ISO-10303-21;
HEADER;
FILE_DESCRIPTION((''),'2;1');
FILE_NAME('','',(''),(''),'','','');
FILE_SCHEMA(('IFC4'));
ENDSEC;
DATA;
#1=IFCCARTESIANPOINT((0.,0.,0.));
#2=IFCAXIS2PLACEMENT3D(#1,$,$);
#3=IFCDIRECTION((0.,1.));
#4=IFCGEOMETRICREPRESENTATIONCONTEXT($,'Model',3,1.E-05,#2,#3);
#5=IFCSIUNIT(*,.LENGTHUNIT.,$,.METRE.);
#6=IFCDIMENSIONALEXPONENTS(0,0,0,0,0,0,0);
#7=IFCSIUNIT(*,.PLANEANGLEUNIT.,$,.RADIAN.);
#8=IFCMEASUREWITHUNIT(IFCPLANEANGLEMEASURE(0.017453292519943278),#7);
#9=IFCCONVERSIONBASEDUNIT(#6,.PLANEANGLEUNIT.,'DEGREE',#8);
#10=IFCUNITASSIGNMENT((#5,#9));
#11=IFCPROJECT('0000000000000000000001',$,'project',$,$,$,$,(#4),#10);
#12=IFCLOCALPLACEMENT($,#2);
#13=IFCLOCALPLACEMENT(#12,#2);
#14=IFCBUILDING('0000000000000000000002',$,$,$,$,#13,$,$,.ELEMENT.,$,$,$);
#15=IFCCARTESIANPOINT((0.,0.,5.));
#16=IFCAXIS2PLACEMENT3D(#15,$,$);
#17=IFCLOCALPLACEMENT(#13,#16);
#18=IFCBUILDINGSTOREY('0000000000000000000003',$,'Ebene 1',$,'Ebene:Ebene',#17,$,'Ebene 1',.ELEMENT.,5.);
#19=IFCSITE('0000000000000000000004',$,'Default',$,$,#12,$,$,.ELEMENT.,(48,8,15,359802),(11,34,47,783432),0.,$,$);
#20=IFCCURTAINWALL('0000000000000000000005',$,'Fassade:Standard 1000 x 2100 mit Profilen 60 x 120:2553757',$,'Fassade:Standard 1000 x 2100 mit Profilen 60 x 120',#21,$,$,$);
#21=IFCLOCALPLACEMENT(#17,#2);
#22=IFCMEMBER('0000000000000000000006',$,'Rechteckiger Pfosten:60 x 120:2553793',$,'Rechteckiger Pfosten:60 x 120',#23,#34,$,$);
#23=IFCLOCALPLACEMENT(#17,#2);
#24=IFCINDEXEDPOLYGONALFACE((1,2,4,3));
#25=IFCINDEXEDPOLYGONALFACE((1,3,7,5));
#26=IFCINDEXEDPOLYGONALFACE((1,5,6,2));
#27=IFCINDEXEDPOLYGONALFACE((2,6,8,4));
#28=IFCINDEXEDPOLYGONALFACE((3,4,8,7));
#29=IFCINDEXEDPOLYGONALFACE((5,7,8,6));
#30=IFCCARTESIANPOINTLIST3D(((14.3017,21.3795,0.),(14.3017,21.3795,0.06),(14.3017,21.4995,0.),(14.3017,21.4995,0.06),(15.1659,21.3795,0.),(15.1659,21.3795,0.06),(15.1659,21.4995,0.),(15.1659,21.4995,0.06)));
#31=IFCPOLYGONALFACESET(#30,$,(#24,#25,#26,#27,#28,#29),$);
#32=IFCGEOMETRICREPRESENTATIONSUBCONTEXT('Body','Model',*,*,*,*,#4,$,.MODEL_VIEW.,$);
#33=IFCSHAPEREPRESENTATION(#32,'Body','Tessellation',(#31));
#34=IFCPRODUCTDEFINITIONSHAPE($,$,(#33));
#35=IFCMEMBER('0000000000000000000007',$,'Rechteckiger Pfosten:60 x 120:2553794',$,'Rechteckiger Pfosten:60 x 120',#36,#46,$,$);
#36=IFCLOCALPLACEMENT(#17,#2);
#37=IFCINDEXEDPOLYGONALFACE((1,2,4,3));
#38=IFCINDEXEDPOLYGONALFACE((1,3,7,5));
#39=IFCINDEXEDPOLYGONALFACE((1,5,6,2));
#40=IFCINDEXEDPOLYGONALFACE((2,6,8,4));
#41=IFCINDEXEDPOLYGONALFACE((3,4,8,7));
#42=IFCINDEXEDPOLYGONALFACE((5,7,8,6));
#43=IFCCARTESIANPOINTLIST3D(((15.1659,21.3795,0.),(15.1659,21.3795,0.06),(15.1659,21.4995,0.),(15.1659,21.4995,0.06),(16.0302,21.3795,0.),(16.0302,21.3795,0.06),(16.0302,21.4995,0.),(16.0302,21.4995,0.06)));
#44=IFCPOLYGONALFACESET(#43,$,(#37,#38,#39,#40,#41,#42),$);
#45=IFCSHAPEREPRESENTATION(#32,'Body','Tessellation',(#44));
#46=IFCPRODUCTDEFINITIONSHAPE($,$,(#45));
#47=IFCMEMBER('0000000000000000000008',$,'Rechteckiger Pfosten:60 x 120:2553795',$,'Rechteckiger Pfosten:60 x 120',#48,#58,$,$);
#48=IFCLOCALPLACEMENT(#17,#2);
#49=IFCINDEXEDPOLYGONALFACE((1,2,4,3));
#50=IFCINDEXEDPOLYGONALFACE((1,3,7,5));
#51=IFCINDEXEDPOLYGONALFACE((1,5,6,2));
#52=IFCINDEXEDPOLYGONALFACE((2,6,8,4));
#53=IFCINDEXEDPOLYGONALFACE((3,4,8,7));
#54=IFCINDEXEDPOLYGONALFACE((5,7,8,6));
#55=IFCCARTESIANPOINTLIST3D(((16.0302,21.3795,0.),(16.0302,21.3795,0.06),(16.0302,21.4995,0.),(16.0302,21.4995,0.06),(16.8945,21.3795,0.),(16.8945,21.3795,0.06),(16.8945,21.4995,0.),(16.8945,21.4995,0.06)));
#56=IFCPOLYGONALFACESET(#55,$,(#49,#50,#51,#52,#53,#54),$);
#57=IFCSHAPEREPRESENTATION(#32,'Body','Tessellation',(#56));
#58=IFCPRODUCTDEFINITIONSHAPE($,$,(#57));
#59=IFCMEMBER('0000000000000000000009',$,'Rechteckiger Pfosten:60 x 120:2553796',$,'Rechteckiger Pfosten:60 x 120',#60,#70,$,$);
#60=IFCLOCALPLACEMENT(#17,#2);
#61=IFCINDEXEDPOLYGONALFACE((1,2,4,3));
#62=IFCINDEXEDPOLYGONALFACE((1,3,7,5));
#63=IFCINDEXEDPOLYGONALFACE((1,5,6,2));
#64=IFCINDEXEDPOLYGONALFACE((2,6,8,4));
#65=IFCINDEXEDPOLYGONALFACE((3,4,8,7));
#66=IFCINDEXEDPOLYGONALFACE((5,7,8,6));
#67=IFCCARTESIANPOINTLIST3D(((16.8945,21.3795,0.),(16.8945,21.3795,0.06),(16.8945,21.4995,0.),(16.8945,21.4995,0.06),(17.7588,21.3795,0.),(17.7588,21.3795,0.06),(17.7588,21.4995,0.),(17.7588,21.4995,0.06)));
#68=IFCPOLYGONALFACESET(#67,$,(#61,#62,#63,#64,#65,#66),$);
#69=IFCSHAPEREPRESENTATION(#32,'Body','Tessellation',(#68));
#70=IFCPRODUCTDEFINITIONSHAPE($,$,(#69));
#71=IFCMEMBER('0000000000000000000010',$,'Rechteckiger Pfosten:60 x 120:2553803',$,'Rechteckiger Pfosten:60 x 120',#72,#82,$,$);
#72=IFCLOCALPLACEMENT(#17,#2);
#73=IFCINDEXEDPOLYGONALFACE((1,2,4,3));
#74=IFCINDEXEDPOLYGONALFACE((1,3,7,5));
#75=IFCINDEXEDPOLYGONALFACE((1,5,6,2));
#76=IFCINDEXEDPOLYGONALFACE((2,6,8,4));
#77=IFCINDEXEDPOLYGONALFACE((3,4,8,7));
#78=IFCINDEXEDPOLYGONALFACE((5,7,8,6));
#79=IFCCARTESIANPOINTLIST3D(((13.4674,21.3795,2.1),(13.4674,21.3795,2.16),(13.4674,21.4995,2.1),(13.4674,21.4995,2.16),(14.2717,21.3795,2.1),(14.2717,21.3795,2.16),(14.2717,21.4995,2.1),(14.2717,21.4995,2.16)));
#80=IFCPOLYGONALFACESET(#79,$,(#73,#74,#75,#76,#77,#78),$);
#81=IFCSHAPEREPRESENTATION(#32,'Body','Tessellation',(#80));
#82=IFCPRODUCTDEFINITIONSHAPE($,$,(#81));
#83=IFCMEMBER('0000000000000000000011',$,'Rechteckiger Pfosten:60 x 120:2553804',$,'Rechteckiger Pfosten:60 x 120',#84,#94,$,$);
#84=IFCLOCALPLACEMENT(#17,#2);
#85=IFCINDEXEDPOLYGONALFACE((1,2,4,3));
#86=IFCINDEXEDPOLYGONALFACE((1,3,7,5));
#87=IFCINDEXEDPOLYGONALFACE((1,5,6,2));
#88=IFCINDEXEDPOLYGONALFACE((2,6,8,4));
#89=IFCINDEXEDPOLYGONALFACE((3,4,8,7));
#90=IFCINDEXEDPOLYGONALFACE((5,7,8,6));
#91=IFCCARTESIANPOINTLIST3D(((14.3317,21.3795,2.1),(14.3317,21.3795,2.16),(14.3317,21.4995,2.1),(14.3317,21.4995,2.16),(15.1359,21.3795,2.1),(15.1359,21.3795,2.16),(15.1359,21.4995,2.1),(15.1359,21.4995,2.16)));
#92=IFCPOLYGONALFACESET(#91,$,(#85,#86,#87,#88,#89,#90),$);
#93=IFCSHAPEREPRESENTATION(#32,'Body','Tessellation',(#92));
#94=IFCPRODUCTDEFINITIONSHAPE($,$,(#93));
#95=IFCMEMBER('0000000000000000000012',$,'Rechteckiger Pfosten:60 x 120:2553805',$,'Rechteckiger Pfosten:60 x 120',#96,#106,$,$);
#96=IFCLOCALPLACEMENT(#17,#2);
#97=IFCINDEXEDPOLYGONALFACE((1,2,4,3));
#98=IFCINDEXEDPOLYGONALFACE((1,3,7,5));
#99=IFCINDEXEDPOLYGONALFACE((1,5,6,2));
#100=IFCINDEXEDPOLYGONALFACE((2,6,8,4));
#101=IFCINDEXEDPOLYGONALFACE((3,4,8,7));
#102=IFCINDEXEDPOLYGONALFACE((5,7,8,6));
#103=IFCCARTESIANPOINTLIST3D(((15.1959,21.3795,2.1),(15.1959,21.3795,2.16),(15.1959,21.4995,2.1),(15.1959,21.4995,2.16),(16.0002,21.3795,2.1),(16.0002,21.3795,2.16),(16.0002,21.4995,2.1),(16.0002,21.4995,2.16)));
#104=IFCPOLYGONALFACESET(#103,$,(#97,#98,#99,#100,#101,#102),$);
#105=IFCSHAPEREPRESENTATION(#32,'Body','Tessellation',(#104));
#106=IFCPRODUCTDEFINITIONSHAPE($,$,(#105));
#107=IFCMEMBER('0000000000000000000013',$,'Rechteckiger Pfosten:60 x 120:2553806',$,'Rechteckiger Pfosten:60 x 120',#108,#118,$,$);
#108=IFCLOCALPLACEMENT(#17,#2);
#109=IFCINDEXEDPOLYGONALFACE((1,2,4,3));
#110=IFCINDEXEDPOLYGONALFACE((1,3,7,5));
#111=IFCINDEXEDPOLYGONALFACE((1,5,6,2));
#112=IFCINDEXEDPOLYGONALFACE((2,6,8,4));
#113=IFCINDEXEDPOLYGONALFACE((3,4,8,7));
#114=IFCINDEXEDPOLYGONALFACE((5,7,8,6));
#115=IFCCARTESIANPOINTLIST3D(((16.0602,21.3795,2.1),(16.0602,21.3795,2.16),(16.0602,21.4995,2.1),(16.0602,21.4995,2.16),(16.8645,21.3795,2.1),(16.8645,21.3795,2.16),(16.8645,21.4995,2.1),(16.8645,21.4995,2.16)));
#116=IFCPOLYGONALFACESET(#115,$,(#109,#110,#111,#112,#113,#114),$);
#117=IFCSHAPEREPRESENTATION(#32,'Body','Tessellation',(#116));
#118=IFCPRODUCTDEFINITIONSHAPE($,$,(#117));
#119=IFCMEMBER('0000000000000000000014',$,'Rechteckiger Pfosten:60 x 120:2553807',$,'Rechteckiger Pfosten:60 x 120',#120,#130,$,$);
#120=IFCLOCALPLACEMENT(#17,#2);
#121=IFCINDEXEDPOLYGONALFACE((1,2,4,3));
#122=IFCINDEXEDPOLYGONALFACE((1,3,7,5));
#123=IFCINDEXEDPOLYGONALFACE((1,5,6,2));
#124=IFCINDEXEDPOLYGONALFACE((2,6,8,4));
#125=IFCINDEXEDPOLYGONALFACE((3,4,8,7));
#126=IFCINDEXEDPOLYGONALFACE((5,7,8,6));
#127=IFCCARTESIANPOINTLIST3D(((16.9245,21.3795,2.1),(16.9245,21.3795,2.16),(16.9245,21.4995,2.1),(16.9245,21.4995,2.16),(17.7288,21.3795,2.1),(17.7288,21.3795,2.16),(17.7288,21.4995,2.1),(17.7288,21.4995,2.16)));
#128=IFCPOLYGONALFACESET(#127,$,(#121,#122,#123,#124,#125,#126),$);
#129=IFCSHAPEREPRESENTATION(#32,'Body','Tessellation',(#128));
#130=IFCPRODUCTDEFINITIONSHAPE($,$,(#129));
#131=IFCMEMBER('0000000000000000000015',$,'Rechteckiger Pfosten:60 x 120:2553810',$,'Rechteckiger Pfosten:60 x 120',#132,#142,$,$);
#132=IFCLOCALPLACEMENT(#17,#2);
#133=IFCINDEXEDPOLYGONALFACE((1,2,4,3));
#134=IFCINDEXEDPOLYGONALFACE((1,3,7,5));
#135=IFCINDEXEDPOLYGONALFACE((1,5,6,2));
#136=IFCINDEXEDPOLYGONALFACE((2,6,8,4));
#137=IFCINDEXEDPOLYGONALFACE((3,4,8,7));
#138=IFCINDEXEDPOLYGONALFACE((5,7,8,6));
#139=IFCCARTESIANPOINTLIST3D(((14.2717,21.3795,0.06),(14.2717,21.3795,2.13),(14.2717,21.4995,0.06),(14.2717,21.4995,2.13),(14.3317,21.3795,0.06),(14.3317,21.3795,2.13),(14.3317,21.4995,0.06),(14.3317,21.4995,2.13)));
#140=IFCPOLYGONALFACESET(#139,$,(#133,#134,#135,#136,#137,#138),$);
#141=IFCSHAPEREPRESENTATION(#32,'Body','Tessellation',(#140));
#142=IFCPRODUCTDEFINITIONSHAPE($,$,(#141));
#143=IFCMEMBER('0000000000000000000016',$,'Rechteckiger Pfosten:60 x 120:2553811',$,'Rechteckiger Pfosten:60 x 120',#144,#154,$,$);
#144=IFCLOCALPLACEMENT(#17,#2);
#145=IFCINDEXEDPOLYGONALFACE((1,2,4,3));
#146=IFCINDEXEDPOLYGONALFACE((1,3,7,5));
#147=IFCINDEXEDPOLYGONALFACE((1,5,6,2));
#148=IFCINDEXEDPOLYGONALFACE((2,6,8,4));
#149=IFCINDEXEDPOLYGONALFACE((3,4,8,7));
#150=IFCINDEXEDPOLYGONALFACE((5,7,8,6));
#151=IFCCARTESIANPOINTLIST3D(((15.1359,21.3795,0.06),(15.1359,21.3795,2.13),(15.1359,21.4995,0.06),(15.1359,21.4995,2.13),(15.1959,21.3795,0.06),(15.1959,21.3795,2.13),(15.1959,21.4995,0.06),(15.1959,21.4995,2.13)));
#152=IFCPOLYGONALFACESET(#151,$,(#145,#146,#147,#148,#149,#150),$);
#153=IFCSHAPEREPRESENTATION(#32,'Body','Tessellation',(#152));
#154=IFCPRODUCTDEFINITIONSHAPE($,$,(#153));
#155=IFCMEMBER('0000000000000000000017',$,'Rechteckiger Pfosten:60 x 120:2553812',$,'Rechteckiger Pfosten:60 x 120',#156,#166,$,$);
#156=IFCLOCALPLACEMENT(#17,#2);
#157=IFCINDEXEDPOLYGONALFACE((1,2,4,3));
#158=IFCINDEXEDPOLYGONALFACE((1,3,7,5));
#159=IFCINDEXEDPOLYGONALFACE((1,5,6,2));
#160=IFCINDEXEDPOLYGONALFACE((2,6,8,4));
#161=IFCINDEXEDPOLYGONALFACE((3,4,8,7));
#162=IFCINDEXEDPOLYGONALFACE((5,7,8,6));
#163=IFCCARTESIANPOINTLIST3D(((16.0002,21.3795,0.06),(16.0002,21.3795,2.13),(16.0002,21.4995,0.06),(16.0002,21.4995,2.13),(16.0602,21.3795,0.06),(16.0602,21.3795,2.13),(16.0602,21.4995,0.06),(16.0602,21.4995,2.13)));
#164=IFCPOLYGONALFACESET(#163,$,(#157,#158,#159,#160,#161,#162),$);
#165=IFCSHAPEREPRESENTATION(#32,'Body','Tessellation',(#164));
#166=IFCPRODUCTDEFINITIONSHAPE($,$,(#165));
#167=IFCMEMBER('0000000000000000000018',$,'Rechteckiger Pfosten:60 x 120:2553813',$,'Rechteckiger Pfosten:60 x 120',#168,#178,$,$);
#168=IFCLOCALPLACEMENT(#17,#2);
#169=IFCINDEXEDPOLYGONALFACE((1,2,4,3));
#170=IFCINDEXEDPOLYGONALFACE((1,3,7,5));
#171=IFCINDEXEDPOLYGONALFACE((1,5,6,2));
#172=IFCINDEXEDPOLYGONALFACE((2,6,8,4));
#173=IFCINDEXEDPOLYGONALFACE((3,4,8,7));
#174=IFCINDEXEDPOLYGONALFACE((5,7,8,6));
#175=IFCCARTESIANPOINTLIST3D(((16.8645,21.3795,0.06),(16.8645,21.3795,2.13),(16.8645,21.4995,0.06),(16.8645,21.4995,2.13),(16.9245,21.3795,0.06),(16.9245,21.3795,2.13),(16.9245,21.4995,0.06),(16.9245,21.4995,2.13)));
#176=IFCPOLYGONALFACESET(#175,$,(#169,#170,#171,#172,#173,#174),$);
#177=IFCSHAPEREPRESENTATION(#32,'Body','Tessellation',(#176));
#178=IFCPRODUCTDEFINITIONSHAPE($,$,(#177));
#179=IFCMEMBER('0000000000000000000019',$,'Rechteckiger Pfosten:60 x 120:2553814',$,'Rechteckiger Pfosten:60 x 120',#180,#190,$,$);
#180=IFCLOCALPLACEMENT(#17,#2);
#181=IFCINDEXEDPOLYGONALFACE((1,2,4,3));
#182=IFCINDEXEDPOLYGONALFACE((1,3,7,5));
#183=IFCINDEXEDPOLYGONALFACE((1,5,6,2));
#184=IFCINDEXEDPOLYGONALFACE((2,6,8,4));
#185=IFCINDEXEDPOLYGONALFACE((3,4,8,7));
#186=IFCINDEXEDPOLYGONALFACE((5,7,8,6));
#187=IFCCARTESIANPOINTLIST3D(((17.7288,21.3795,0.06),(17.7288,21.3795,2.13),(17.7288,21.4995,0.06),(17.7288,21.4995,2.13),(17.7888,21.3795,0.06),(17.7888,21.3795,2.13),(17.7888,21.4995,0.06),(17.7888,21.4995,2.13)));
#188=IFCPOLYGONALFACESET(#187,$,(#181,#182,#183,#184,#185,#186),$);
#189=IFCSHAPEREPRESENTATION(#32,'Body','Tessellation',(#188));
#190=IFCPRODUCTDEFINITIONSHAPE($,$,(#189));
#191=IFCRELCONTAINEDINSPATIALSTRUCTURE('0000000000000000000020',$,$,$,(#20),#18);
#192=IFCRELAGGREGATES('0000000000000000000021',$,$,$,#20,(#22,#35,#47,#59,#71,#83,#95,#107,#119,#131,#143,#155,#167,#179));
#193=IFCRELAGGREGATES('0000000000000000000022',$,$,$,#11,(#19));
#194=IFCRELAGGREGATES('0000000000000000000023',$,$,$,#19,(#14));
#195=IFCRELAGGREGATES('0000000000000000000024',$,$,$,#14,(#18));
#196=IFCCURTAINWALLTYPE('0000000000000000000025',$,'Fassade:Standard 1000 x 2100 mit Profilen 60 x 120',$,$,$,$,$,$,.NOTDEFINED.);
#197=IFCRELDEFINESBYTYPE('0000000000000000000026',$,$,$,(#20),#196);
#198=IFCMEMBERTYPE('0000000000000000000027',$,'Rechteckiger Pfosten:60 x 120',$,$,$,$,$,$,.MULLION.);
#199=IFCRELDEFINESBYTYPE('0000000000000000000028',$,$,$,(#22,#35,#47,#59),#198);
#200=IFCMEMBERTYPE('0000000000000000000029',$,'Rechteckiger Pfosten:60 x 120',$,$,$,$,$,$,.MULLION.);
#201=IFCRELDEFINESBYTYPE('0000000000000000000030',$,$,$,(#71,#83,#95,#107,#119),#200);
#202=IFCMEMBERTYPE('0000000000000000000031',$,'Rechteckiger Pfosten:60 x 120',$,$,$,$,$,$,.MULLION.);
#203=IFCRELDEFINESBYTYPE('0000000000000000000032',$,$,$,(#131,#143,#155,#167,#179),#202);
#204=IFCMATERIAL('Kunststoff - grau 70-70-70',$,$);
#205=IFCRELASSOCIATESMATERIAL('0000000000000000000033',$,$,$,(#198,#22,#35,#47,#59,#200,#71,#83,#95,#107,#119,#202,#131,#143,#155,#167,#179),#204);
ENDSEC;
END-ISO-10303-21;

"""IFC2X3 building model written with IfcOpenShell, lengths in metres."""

from ifc_helpers import new_model, entity, si_unit, converted_unit, direction, frame, frame_2d, origin, origin_2d_with_axis, place, context, subcontext, project, spatial, rectangle, extrude, source, transform, mapped, material, type_object, type_shapes, element, aggregate, save


model = new_model("IFC2X3")

# Units and contexts
model_context = context("Model", 3, precision=1e-05, world=origin(), true_north=direction((0.0, 1.0)))
body_context = subcontext(model_context, "Body", "Model", "MODEL_VIEW")
ifc_project = project(units=[si_unit("LENGTHUNIT", "METRE"), converted_unit("PLANEANGLEUNIT", "DEGREE", entity("IfcPlaneAngleMeasure", 0.017453292519943278), si_unit("PLANEANGLEUNIT", "RADIAN"), dimensions=[0, 0, 0, 0, 0, 0, 0])], contexts=[model_context])

# Site, building, storey
site_placement = place(None, origin())
site = spatial("IfcSite", under=ifc_project, at=site_placement, Name="Default", CompositionType="ELEMENT", RefLatitude=(48, 8, 15, 359802), RefLongitude=(11, 34, 47, 783432), RefElevation=0.0)
building_placement = place(site_placement, origin())
building = spatial("IfcBuilding", under=site, at=building_placement, CompositionType="ELEMENT")
storey_placement = place(building_placement, frame((0.0, 0.0, 5.0)))
storey = spatial("IfcBuildingStorey", under=building, at=storey_placement, Name="Ebene 1", ObjectType="Ebene:Ebene", LongName="Ebene 1", CompositionType="ELEMENT", Elevation=5.0)

# Curtain wall, members
curtain_wall_type = type_object("IfcCurtainWallType", Name="Fassade:Standard 1000 x 2100 mit Profilen 60 x 120", PredefinedType="NOTDEFINED")
curtain_wall_placement = place(storey_placement, frame((0.0, 0.0, -5.0)))
curtain_wall = element("IfcCurtainWall", 1, at=curtain_wall_placement, inside=storey, type_object=curtain_wall_type, Name="Fassade:Standard 1000 x 2100 mit Profilen 60 x 120:2553757", ObjectType="Fassade:Standard 1000 x 2100 mit Profilen 60 x 120")
ifc_material_1 = material(Name="Kunststoff - grau 70-70-70")
member_type_1 = type_object("IfcMemberType", Name="Rechteckiger Pfosten:60 x 120", PredefinedType="MULLION", material=ifc_material_1)
shared_shape_1 = source(origin(), body_context, "Body", "SweptSolid", [
    extrude(rectangle(XDim=0.06, YDim=0.12, at=origin_2d_with_axis()), frame((-0.03, 0.0, -0.8643), z_axis=(0.0, 0.0, 1.0), x_axis=(-1.0, 0.0, 0.0)), (0.0, 0.0, 1.0), 0.8643),
])
type_shapes(member_type_1, [shared_shape_1])
member_1_placement = place(curtain_wall_placement, frame((14.3017, 21.4395, 5.0), z_axis=(-1.0, 0.0, 0.0), x_axis=(0.0, 0.0, -1.0)))
member_1 = element("IfcMember", 2, at=member_1_placement, type_object=member_type_1, material=ifc_material_1, Name="Rechteckiger Pfosten:60 x 120:2553793", ObjectType="Rechteckiger Pfosten:60 x 120", context=body_context, shape_type="MappedRepresentation", body=[
    mapped(shared_shape_1, transform((0.0, 0.0, 0.0), scale=1.0)),
])
member_2_placement = place(curtain_wall_placement, frame((15.1659, 21.4395, 5.0), z_axis=(-1.0, 0.0, 0.0), x_axis=(0.0, 0.0, -1.0)))
member_2 = element("IfcMember", 3, at=member_2_placement, type_object=member_type_1, material=ifc_material_1, Name="Rechteckiger Pfosten:60 x 120:2553794", ObjectType="Rechteckiger Pfosten:60 x 120", context=body_context, shape_type="MappedRepresentation", body=[
    mapped(shared_shape_1, transform((0.0, 0.0, 0.0), scale=1.0)),
])
member_3_placement = place(curtain_wall_placement, frame((16.0302, 21.4395, 5.0), z_axis=(-1.0, 0.0, 0.0), x_axis=(0.0, 0.0, -1.0)))
member_3 = element("IfcMember", 4, at=member_3_placement, type_object=member_type_1, material=ifc_material_1, Name="Rechteckiger Pfosten:60 x 120:2553795", ObjectType="Rechteckiger Pfosten:60 x 120", context=body_context, shape_type="MappedRepresentation", body=[
    mapped(shared_shape_1, transform((0.0, 0.0, 0.0), scale=1.0)),
])
member_4_placement = place(curtain_wall_placement, frame((16.8945, 21.4395, 5.0), z_axis=(-1.0, 0.0, 0.0), x_axis=(0.0, 0.0, -1.0)))
member_4 = element("IfcMember", 5, at=member_4_placement, type_object=member_type_1, material=ifc_material_1, Name="Rechteckiger Pfosten:60 x 120:2553796", ObjectType="Rechteckiger Pfosten:60 x 120", context=body_context, shape_type="MappedRepresentation", body=[
    mapped(shared_shape_1, transform((0.0, 0.0, 0.0), scale=1.0)),
])
member_type_2 = type_object("IfcMemberType", Name="Rechteckiger Pfosten:60 x 120", PredefinedType="MULLION", material=ifc_material_1)
shared_shape_2 = source(origin(), body_context, "Body", "SweptSolid", [
    extrude(rectangle(XDim=0.06, YDim=0.12, at=frame_2d((0.0, 0.0), x_axis=(1.0, 0.0))), frame((0.0, 0.0, -0.8043), z_axis=(0.0, 0.0, 1.0), x_axis=(-1.0, 0.0, 0.0)), (0.0, 0.0, 1.0), 0.8043),
])
type_shapes(member_type_2, [shared_shape_2])
member_5_placement = place(curtain_wall_placement, frame((14.2717, 21.4395, 7.13), z_axis=(1.0, 0.0, 0.0), x_axis=(0.0, 0.0, 1.0)))
member_5 = element("IfcMember", 6, at=member_5_placement, type_object=member_type_2, material=ifc_material_1, Name="Rechteckiger Pfosten:60 x 120:2553803", ObjectType="Rechteckiger Pfosten:60 x 120", context=body_context, shape_type="MappedRepresentation", body=[
    mapped(shared_shape_2, transform((0.0, 0.0, 0.0), scale=1.0)),
])
member_6_placement = place(curtain_wall_placement, frame((15.1359, 21.4395, 7.13), z_axis=(1.0, 0.0, 0.0), x_axis=(0.0, 0.0, 1.0)))
member_6 = element("IfcMember", 7, at=member_6_placement, type_object=member_type_2, material=ifc_material_1, Name="Rechteckiger Pfosten:60 x 120:2553804", ObjectType="Rechteckiger Pfosten:60 x 120", context=body_context, shape_type="MappedRepresentation", body=[
    mapped(shared_shape_2, transform((0.0, 0.0, 0.0), scale=1.0)),
])
member_7_placement = place(curtain_wall_placement, frame((16.0002, 21.4395, 7.13), z_axis=(1.0, 0.0, 0.0), x_axis=(0.0, 0.0, 1.0)))
member_7 = element("IfcMember", 8, at=member_7_placement, type_object=member_type_2, material=ifc_material_1, Name="Rechteckiger Pfosten:60 x 120:2553805", ObjectType="Rechteckiger Pfosten:60 x 120", context=body_context, shape_type="MappedRepresentation", body=[
    mapped(shared_shape_2, transform((0.0, 0.0, 0.0), scale=1.0)),
])
member_8_placement = place(curtain_wall_placement, frame((16.8645, 21.4395, 7.13), z_axis=(1.0, 0.0, 0.0), x_axis=(0.0, 0.0, 1.0)))
member_8 = element("IfcMember", 9, at=member_8_placement, type_object=member_type_2, material=ifc_material_1, Name="Rechteckiger Pfosten:60 x 120:2553806", ObjectType="Rechteckiger Pfosten:60 x 120", context=body_context, shape_type="MappedRepresentation", body=[
    mapped(shared_shape_2, transform((0.0, 0.0, 0.0), scale=1.0)),
])
member_9_placement = place(curtain_wall_placement, frame((17.7288, 21.4395, 7.13), z_axis=(1.0, 0.0, 0.0), x_axis=(0.0, 0.0, 1.0)))
member_9 = element("IfcMember", 10, at=member_9_placement, type_object=member_type_2, material=ifc_material_1, Name="Rechteckiger Pfosten:60 x 120:2553807", ObjectType="Rechteckiger Pfosten:60 x 120", context=body_context, shape_type="MappedRepresentation", body=[
    mapped(shared_shape_2, transform((0.0, 0.0, 0.0), scale=1.0)),
])
member_type_3 = type_object("IfcMemberType", Name="Rechteckiger Pfosten:60 x 120", PredefinedType="MULLION", material=ifc_material_1)
shared_shape_3 = source(origin(), body_context, "Body", "SweptSolid", [
    extrude(rectangle(XDim=0.06, YDim=0.12, at=origin_2d_with_axis()), frame((0.0, 0.0, -2.07), z_axis=(0.0, 0.0, 1.0), x_axis=(-1.0, 0.0, 0.0)), (0.0, 0.0, 1.0), 2.07),
])
type_shapes(member_type_3, [shared_shape_3])
member_10_placement = place(curtain_wall_placement, frame((14.3017, 21.4395, 5.06), z_axis=(0.0, 0.0, -1.0), x_axis=(1.0, 0.0, 0.0)))
member_10 = element("IfcMember", 11, at=member_10_placement, type_object=member_type_3, material=ifc_material_1, Name="Rechteckiger Pfosten:60 x 120:2553810", ObjectType="Rechteckiger Pfosten:60 x 120", context=body_context, shape_type="MappedRepresentation", body=[
    mapped(shared_shape_3, transform((0.0, 0.0, 0.0), scale=1.0)),
])
member_11_placement = place(curtain_wall_placement, frame((15.1659, 21.4395, 5.06), z_axis=(0.0, 0.0, -1.0), x_axis=(1.0, 0.0, 0.0)))
member_11 = element("IfcMember", 12, at=member_11_placement, type_object=member_type_3, material=ifc_material_1, Name="Rechteckiger Pfosten:60 x 120:2553811", ObjectType="Rechteckiger Pfosten:60 x 120", context=body_context, shape_type="MappedRepresentation", body=[
    mapped(shared_shape_3, transform((0.0, 0.0, 0.0), scale=1.0)),
])
member_12_placement = place(curtain_wall_placement, frame((16.0302, 21.4395, 5.06), z_axis=(0.0, 0.0, -1.0), x_axis=(1.0, 0.0, 0.0)))
member_12 = element("IfcMember", 13, at=member_12_placement, type_object=member_type_3, material=ifc_material_1, Name="Rechteckiger Pfosten:60 x 120:2553812", ObjectType="Rechteckiger Pfosten:60 x 120", context=body_context, shape_type="MappedRepresentation", body=[
    mapped(shared_shape_3, transform((0.0, 0.0, 0.0), scale=1.0)),
])
member_13_placement = place(curtain_wall_placement, frame((16.8945, 21.4395, 5.06), z_axis=(0.0, 0.0, -1.0), x_axis=(1.0, 0.0, 0.0)))
member_13 = element("IfcMember", 14, at=member_13_placement, type_object=member_type_3, material=ifc_material_1, Name="Rechteckiger Pfosten:60 x 120:2553813", ObjectType="Rechteckiger Pfosten:60 x 120", context=body_context, shape_type="MappedRepresentation", body=[
    mapped(shared_shape_3, transform((0.0, 0.0, 0.0), scale=1.0)),
])
member_14_placement = place(curtain_wall_placement, frame((17.7588, 21.4395, 5.06), z_axis=(0.0, 0.0, -1.0), x_axis=(1.0, 0.0, 0.0)))
member_14 = element("IfcMember", 15, at=member_14_placement, type_object=member_type_3, material=ifc_material_1, Name="Rechteckiger Pfosten:60 x 120:2553814", ObjectType="Rechteckiger Pfosten:60 x 120", context=body_context, shape_type="MappedRepresentation", body=[
    mapped(shared_shape_3, transform((0.0, 0.0, 0.0), scale=1.0)),
])
aggregate(curtain_wall, [member_1, member_2, member_3, member_4, member_5, member_6, member_7, member_8, member_9, member_10, member_11, member_12, member_13, member_14])

save(model, "model.ifc")
